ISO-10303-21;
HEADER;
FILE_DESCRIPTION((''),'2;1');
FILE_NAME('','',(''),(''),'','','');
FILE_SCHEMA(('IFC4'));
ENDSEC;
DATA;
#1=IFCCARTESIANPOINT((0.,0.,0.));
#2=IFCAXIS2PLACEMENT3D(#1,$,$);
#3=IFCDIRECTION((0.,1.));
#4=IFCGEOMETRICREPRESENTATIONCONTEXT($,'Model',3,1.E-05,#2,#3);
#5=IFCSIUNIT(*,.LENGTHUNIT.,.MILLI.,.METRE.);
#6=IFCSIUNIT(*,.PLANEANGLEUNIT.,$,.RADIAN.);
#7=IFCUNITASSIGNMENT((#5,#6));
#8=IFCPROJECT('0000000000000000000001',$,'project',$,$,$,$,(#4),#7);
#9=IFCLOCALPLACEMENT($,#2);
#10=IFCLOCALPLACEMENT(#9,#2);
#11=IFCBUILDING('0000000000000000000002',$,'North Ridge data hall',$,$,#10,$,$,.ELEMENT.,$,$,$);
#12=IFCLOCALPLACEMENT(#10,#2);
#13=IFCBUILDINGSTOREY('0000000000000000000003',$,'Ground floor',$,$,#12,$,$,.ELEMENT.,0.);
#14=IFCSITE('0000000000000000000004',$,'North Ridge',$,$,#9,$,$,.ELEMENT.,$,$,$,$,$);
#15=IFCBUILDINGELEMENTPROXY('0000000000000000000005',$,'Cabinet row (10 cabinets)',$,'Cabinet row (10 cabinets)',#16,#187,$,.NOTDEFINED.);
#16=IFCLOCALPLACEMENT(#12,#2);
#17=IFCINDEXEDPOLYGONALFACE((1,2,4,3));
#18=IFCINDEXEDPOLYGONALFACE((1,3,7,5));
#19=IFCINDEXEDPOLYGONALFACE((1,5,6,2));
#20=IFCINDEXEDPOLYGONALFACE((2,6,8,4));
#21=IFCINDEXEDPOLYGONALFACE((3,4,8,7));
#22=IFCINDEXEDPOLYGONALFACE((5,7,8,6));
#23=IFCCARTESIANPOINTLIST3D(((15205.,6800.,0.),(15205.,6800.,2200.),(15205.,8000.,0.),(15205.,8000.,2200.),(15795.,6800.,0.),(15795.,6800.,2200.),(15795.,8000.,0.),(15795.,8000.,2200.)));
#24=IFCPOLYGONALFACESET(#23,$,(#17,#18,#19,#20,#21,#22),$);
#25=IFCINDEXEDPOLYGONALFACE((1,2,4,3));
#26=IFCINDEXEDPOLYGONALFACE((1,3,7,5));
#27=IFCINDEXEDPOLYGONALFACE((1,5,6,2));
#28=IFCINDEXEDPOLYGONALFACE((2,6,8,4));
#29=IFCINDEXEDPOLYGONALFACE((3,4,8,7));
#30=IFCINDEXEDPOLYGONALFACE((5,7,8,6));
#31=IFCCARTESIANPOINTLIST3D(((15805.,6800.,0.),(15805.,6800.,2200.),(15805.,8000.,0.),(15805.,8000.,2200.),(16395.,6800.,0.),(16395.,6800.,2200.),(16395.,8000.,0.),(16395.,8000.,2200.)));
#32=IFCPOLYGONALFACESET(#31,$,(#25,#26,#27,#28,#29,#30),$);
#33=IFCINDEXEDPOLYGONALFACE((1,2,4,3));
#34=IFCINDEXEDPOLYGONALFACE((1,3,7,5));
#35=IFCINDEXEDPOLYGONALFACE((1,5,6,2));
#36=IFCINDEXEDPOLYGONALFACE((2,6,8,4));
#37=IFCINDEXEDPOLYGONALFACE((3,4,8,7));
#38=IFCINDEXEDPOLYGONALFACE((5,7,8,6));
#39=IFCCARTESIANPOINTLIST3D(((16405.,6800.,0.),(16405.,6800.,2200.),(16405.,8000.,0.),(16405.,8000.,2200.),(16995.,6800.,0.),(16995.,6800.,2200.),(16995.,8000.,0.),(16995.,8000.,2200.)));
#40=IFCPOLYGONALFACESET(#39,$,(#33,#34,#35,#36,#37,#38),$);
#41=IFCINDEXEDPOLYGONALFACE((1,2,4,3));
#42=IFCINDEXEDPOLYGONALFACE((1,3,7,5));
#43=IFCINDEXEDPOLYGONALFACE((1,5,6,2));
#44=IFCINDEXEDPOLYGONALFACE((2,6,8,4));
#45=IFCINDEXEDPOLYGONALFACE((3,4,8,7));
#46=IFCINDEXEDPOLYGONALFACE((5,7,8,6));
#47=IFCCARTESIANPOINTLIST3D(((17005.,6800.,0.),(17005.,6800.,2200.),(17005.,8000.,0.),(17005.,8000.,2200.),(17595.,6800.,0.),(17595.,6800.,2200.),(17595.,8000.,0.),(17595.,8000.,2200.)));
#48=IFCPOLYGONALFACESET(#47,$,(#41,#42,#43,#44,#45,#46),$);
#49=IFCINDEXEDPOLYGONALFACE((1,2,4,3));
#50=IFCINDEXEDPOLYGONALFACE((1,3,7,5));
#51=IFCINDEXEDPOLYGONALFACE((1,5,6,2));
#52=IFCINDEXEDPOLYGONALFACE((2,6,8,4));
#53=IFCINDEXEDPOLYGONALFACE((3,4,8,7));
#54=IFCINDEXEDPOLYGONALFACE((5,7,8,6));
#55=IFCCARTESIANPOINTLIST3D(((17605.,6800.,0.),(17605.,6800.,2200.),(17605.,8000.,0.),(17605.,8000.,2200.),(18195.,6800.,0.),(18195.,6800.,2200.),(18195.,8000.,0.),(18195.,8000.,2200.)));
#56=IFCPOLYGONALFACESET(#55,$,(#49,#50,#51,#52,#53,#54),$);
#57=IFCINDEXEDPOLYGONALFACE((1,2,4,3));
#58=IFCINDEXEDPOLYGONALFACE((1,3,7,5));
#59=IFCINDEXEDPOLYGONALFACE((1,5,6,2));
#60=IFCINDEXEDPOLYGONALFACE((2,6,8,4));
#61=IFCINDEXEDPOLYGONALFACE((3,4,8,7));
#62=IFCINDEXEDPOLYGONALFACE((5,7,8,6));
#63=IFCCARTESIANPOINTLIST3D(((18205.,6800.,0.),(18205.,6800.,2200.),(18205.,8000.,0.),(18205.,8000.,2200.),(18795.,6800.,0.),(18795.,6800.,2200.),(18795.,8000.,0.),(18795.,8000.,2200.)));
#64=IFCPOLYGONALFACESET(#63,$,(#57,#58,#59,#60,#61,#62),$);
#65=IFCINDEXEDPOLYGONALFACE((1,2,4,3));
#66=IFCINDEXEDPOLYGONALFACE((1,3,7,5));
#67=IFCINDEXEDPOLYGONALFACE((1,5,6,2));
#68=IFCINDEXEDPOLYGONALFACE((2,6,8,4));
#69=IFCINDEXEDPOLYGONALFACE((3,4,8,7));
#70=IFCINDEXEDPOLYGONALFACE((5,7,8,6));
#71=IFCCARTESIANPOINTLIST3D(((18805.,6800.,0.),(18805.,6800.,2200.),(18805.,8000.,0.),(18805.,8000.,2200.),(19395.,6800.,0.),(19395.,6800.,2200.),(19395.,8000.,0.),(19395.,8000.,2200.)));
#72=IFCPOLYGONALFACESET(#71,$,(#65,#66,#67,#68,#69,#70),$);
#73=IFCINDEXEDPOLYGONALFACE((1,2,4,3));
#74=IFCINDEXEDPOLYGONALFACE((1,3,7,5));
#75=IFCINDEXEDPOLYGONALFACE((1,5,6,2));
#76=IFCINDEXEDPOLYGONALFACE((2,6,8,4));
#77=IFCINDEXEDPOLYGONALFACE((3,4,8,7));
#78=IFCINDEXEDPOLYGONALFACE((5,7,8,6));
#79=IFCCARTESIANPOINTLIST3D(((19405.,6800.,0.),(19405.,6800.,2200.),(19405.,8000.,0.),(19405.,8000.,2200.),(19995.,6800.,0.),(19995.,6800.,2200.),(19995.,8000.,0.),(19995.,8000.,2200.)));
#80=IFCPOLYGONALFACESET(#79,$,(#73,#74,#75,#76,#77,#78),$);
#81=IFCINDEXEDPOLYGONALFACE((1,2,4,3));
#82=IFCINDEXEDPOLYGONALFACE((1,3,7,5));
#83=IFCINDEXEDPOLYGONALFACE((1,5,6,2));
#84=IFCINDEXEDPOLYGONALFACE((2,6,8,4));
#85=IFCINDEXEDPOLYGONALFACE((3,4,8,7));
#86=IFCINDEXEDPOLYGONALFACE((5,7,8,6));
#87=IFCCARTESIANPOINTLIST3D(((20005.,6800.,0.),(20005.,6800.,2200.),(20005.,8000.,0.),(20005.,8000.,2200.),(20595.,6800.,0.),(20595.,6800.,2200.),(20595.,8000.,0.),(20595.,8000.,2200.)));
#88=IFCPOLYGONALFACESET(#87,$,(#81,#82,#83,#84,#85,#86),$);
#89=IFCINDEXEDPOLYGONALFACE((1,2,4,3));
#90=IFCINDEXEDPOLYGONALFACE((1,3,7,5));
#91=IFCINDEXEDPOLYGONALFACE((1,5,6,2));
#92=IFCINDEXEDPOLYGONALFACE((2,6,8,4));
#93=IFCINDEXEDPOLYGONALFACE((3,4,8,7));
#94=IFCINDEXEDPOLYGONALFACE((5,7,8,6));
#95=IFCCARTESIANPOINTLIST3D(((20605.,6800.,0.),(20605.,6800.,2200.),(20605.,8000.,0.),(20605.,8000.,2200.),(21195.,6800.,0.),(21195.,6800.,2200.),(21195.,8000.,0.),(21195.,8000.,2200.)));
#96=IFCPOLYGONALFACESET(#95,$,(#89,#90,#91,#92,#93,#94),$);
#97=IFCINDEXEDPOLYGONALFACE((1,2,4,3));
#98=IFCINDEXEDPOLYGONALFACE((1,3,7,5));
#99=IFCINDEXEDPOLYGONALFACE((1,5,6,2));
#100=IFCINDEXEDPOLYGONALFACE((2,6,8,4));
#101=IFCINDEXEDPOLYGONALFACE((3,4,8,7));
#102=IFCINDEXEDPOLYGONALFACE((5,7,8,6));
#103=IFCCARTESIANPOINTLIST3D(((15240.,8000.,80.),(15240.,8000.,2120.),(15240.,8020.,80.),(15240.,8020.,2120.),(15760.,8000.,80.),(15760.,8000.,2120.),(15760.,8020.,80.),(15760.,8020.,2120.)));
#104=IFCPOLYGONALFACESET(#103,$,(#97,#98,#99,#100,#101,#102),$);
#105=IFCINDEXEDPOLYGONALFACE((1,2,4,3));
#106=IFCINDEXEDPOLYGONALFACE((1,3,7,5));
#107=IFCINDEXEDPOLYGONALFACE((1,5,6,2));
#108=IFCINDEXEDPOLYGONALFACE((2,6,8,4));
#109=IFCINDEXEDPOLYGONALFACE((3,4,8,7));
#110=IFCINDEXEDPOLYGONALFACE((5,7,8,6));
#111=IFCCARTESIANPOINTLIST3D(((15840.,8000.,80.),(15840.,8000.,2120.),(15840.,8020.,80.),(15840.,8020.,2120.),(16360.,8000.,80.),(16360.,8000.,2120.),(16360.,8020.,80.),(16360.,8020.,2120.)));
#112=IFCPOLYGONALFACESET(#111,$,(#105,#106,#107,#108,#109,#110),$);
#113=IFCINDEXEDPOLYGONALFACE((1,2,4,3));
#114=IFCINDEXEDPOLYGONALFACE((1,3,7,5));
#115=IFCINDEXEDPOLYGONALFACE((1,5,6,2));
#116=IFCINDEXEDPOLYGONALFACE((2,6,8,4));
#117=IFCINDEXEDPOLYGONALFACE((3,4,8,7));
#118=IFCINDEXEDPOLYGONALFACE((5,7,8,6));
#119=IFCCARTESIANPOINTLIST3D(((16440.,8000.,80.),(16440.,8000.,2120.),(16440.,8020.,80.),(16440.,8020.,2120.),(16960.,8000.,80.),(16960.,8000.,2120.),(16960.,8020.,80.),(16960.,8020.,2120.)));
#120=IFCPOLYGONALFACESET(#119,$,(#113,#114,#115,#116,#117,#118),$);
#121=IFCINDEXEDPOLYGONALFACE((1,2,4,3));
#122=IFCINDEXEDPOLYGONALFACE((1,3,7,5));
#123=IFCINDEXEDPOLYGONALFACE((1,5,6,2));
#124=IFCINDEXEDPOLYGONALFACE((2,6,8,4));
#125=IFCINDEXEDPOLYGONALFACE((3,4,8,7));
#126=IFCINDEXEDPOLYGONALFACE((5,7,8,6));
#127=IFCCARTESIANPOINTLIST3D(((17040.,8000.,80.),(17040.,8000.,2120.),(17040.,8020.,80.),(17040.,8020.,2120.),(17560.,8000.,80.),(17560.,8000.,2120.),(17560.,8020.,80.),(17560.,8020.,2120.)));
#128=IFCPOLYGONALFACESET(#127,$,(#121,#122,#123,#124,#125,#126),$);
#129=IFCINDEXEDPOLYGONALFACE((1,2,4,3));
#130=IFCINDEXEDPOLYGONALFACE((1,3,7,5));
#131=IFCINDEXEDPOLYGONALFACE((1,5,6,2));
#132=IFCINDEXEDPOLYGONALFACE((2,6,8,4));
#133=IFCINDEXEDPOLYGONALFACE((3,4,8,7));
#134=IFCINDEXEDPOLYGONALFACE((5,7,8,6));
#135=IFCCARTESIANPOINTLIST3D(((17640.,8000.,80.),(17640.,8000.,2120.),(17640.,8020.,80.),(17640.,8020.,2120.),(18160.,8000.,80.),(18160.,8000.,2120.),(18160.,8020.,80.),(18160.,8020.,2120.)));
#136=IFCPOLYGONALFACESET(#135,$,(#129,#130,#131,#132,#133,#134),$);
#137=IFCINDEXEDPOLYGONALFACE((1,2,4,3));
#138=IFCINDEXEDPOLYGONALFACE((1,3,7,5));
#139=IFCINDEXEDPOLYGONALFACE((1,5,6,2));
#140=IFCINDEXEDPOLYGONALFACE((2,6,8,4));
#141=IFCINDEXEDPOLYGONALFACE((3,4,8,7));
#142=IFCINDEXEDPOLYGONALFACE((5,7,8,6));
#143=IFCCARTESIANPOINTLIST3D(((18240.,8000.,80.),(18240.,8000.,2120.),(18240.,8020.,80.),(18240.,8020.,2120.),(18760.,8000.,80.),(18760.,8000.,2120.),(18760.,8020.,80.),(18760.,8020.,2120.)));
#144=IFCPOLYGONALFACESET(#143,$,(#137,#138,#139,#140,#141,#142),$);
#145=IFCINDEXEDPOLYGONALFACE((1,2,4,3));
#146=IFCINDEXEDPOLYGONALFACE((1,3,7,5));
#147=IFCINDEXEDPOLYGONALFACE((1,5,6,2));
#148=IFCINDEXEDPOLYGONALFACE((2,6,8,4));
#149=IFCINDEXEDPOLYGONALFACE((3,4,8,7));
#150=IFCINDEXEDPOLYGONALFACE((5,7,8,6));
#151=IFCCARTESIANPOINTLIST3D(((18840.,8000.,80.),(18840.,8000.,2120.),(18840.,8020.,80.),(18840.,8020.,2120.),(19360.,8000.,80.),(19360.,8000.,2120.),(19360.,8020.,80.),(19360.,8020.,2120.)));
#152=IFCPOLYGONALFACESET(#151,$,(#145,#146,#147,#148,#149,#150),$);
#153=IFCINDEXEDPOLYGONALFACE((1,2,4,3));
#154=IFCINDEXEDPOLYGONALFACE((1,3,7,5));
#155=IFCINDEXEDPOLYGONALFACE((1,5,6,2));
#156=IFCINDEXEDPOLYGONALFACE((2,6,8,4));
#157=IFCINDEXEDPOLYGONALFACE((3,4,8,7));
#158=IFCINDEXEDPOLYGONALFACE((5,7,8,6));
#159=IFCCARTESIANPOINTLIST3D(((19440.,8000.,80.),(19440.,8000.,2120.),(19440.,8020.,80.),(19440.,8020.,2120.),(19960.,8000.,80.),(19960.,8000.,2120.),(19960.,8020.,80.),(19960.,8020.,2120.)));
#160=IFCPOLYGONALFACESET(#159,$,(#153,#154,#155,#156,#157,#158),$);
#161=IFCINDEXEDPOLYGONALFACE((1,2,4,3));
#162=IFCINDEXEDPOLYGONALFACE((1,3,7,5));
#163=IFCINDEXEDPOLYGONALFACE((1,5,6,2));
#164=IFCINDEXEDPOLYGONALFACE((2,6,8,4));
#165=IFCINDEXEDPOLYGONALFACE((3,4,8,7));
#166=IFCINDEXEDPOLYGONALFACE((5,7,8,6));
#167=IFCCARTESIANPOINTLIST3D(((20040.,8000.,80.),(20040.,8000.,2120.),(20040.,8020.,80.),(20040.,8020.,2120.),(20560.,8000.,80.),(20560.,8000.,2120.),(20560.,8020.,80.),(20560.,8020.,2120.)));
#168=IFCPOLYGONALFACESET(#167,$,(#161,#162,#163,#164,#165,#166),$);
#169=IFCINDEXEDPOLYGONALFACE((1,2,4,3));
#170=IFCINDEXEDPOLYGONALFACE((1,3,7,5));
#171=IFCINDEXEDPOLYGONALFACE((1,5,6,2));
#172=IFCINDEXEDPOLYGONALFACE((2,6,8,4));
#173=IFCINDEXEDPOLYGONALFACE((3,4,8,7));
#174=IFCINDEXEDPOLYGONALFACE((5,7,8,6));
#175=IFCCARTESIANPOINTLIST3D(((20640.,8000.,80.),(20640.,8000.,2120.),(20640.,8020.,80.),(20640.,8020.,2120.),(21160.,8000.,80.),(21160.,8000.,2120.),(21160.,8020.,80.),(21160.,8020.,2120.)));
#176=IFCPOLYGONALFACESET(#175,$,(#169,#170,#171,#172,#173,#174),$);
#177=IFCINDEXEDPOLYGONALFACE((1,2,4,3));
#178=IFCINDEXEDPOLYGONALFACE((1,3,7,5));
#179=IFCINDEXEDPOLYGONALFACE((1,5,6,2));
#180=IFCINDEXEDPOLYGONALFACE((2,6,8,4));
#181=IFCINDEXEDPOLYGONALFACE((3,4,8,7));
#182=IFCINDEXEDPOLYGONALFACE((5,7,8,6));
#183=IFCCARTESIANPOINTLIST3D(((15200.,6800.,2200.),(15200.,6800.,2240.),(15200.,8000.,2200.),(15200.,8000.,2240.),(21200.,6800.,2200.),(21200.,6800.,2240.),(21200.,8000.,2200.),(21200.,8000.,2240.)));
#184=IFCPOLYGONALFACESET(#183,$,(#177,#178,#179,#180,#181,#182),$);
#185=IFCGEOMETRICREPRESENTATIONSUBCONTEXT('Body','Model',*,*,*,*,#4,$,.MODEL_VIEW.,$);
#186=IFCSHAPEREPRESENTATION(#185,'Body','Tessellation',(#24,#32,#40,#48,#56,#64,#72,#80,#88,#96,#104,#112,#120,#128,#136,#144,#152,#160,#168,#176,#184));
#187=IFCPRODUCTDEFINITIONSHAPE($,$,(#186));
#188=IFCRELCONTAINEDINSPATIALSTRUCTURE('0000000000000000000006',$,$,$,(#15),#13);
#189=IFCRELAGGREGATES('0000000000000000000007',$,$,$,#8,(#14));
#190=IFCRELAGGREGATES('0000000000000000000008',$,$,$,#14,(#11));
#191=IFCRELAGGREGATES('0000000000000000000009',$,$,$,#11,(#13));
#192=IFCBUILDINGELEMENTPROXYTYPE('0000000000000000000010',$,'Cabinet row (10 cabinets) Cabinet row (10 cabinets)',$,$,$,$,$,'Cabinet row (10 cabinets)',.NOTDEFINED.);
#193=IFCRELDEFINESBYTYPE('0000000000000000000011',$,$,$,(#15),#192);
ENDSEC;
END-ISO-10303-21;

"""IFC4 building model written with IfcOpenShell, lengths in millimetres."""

from ifc_helpers import new_model, si_unit, direction, frame, origin, place, context, subcontext, project, spatial, polyline, outline, extrude, source, transform, mapped, type_object, type_shapes, element, save


model = new_model("IFC4")

# Units and contexts
model_context = context("Model", 3, precision=1e-05, world=origin(), true_north=direction((0.0, 1.0)))
body_context = subcontext(model_context, "Body", "Model", "MODEL_VIEW")
ifc_project = project(units=[si_unit("LENGTHUNIT", "METRE", prefix="MILLI"), si_unit("PLANEANGLEUNIT", "RADIAN")], contexts=[model_context])

# Site, building, storey
site_placement = place(None, origin())
site = spatial("IfcSite", under=ifc_project, at=site_placement, Name="North Ridge", CompositionType="ELEMENT")
building_placement = place(site_placement, origin())
building = spatial("IfcBuilding", under=site, at=building_placement, Name="North Ridge data hall", CompositionType="ELEMENT")
storey_placement = place(building_placement, origin())
storey = spatial("IfcBuildingStorey", under=building, at=storey_placement, Name="Ground floor", CompositionType="ELEMENT", Elevation=0.0)

# Building element proxy
building_element_proxy_type_1 = type_object("IfcBuildingElementProxyType", Name="Cabinet row (10 cabinets) Cabinet row (10 cabinets)", ElementType="Cabinet row (10 cabinets)", PredefinedType="NOTDEFINED")
shared_shape_1 = source(origin(), body_context, "Body", "SweptSolid", [
    extrude(outline(polyline([(5.0, 0.0), (595.0, 0.0), (595.0, 1200.0), (5.0, 1200.0), (5.0, 0.0)])), origin(), (0.0, 0.0, 1.0), 2200.0),
    extrude(outline(polyline([(605.0, 0.0), (1195.0, 0.0), (1195.0, 1200.0), (605.0, 1200.0), (605.0, 0.0)])), origin(), (0.0, 0.0, 1.0), 2200.0),
    extrude(outline(polyline([(1205.0, 0.0), (1795.0, 0.0), (1795.0, 1200.0), (1205.0, 1200.0), (1205.0, 0.0)])), origin(), (0.0, 0.0, 1.0), 2200.0),
    extrude(outline(polyline([(1805.0, 0.0), (2395.0, 0.0), (2395.0, 1200.0), (1805.0, 1200.0), (1805.0, 0.0)])), origin(), (0.0, 0.0, 1.0), 2200.0),
    extrude(outline(polyline([(2405.0, 0.0), (2995.0, 0.0), (2995.0, 1200.0), (2405.0, 1200.0), (2405.0, 0.0)])), origin(), (0.0, 0.0, 1.0), 2200.0),
    extrude(outline(polyline([(3005.0, 0.0), (3595.0, 0.0), (3595.0, 1200.0), (3005.0, 1200.0), (3005.0, 0.0)])), origin(), (0.0, 0.0, 1.0), 2200.0),
    extrude(outline(polyline([(3605.0, 0.0), (4195.0, 0.0), (4195.0, 1200.0), (3605.0, 1200.0), (3605.0, 0.0)])), origin(), (0.0, 0.0, 1.0), 2200.0),
    extrude(outline(polyline([(4205.0, 0.0), (4795.0, 0.0), (4795.0, 1200.0), (4205.0, 1200.0), (4205.0, 0.0)])), origin(), (0.0, 0.0, 1.0), 2200.0),
    extrude(outline(polyline([(4805.0, 0.0), (5395.0, 0.0), (5395.0, 1200.0), (4805.0, 1200.0), (4805.0, 0.0)])), origin(), (0.0, 0.0, 1.0), 2200.0),
    extrude(outline(polyline([(5405.0, 0.0), (5995.0, 0.0), (5995.0, 1200.0), (5405.0, 1200.0), (5405.0, 0.0)])), origin(), (0.0, 0.0, 1.0), 2200.0),
    extrude(outline(polyline([(40.0, 1200.0), (560.0, 1200.0), (560.0, 1220.0), (40.0, 1220.0), (40.0, 1200.0)])), frame((0.0, 0.0, 80.0)), (0.0, 0.0, 1.0), 2040.0),
    extrude(outline(polyline([(640.0, 1200.0), (1160.0, 1200.0), (1160.0, 1220.0), (640.0, 1220.0), (640.0, 1200.0)])), frame((0.0, 0.0, 80.0)), (0.0, 0.0, 1.0), 2040.0),
    extrude(outline(polyline([(1240.0, 1200.0), (1760.0, 1200.0), (1760.0, 1220.0), (1240.0, 1220.0), (1240.0, 1200.0)])), frame((0.0, 0.0, 80.0)), (0.0, 0.0, 1.0), 2040.0),
    extrude(outline(polyline([(1840.0, 1200.0), (2360.0, 1200.0), (2360.0, 1220.0), (1840.0, 1220.0), (1840.0, 1200.0)])), frame((0.0, 0.0, 80.0)), (0.0, 0.0, 1.0), 2040.0),
    extrude(outline(polyline([(2440.0, 1200.0), (2960.0, 1200.0), (2960.0, 1220.0), (2440.0, 1220.0), (2440.0, 1200.0)])), frame((0.0, 0.0, 80.0)), (0.0, 0.0, 1.0), 2040.0),
    extrude(outline(polyline([(3040.0, 1200.0), (3560.0, 1200.0), (3560.0, 1220.0), (3040.0, 1220.0), (3040.0, 1200.0)])), frame((0.0, 0.0, 80.0)), (0.0, 0.0, 1.0), 2040.0),
    extrude(outline(polyline([(3640.0, 1200.0), (4160.0, 1200.0), (4160.0, 1220.0), (3640.0, 1220.0), (3640.0, 1200.0)])), frame((0.0, 0.0, 80.0)), (0.0, 0.0, 1.0), 2040.0),
    extrude(outline(polyline([(4240.0, 1200.0), (4760.0, 1200.0), (4760.0, 1220.0), (4240.0, 1220.0), (4240.0, 1200.0)])), frame((0.0, 0.0, 80.0)), (0.0, 0.0, 1.0), 2040.0),
    extrude(outline(polyline([(4840.0, 1200.0), (5360.0, 1200.0), (5360.0, 1220.0), (4840.0, 1220.0), (4840.0, 1200.0)])), frame((0.0, 0.0, 80.0)), (0.0, 0.0, 1.0), 2040.0),
    extrude(outline(polyline([(5440.0, 1200.0), (5960.0, 1200.0), (5960.0, 1220.0), (5440.0, 1220.0), (5440.0, 1200.0)])), frame((0.0, 0.0, 80.0)), (0.0, 0.0, 1.0), 2040.0),
    extrude(outline(polyline([(0.0, 0.0), (6000.0, 0.0), (6000.0, 1200.0), (0.0, 1200.0), (0.0, 0.0)])), frame((0.0, 0.0, 2200.0)), (0.0, 0.0, 1.0), 40.0),
])
type_shapes(building_element_proxy_type_1, [shared_shape_1])
for number, where, z_axis, x_axis, name in (
    (1, (15200.0, 6800.0, 0.0), (0.0, 0.0, 1.0), (1.0, 0.0, 0.0), "Cabinet row (10 cabinets)"),
):
    element("IfcBuildingElementProxy", number, at=place(storey_placement, frame(where, z_axis=z_axis, x_axis=x_axis)), inside=storey, type_object=building_element_proxy_type_1, Name=name, ObjectType="Cabinet row (10 cabinets)", PredefinedType="NOTDEFINED", context=body_context, shape_type="MappedRepresentation", body=[
        mapped(shared_shape_1, transform((0.0, 0.0, 0.0))),
    ])

save(model, "model.ifc")
